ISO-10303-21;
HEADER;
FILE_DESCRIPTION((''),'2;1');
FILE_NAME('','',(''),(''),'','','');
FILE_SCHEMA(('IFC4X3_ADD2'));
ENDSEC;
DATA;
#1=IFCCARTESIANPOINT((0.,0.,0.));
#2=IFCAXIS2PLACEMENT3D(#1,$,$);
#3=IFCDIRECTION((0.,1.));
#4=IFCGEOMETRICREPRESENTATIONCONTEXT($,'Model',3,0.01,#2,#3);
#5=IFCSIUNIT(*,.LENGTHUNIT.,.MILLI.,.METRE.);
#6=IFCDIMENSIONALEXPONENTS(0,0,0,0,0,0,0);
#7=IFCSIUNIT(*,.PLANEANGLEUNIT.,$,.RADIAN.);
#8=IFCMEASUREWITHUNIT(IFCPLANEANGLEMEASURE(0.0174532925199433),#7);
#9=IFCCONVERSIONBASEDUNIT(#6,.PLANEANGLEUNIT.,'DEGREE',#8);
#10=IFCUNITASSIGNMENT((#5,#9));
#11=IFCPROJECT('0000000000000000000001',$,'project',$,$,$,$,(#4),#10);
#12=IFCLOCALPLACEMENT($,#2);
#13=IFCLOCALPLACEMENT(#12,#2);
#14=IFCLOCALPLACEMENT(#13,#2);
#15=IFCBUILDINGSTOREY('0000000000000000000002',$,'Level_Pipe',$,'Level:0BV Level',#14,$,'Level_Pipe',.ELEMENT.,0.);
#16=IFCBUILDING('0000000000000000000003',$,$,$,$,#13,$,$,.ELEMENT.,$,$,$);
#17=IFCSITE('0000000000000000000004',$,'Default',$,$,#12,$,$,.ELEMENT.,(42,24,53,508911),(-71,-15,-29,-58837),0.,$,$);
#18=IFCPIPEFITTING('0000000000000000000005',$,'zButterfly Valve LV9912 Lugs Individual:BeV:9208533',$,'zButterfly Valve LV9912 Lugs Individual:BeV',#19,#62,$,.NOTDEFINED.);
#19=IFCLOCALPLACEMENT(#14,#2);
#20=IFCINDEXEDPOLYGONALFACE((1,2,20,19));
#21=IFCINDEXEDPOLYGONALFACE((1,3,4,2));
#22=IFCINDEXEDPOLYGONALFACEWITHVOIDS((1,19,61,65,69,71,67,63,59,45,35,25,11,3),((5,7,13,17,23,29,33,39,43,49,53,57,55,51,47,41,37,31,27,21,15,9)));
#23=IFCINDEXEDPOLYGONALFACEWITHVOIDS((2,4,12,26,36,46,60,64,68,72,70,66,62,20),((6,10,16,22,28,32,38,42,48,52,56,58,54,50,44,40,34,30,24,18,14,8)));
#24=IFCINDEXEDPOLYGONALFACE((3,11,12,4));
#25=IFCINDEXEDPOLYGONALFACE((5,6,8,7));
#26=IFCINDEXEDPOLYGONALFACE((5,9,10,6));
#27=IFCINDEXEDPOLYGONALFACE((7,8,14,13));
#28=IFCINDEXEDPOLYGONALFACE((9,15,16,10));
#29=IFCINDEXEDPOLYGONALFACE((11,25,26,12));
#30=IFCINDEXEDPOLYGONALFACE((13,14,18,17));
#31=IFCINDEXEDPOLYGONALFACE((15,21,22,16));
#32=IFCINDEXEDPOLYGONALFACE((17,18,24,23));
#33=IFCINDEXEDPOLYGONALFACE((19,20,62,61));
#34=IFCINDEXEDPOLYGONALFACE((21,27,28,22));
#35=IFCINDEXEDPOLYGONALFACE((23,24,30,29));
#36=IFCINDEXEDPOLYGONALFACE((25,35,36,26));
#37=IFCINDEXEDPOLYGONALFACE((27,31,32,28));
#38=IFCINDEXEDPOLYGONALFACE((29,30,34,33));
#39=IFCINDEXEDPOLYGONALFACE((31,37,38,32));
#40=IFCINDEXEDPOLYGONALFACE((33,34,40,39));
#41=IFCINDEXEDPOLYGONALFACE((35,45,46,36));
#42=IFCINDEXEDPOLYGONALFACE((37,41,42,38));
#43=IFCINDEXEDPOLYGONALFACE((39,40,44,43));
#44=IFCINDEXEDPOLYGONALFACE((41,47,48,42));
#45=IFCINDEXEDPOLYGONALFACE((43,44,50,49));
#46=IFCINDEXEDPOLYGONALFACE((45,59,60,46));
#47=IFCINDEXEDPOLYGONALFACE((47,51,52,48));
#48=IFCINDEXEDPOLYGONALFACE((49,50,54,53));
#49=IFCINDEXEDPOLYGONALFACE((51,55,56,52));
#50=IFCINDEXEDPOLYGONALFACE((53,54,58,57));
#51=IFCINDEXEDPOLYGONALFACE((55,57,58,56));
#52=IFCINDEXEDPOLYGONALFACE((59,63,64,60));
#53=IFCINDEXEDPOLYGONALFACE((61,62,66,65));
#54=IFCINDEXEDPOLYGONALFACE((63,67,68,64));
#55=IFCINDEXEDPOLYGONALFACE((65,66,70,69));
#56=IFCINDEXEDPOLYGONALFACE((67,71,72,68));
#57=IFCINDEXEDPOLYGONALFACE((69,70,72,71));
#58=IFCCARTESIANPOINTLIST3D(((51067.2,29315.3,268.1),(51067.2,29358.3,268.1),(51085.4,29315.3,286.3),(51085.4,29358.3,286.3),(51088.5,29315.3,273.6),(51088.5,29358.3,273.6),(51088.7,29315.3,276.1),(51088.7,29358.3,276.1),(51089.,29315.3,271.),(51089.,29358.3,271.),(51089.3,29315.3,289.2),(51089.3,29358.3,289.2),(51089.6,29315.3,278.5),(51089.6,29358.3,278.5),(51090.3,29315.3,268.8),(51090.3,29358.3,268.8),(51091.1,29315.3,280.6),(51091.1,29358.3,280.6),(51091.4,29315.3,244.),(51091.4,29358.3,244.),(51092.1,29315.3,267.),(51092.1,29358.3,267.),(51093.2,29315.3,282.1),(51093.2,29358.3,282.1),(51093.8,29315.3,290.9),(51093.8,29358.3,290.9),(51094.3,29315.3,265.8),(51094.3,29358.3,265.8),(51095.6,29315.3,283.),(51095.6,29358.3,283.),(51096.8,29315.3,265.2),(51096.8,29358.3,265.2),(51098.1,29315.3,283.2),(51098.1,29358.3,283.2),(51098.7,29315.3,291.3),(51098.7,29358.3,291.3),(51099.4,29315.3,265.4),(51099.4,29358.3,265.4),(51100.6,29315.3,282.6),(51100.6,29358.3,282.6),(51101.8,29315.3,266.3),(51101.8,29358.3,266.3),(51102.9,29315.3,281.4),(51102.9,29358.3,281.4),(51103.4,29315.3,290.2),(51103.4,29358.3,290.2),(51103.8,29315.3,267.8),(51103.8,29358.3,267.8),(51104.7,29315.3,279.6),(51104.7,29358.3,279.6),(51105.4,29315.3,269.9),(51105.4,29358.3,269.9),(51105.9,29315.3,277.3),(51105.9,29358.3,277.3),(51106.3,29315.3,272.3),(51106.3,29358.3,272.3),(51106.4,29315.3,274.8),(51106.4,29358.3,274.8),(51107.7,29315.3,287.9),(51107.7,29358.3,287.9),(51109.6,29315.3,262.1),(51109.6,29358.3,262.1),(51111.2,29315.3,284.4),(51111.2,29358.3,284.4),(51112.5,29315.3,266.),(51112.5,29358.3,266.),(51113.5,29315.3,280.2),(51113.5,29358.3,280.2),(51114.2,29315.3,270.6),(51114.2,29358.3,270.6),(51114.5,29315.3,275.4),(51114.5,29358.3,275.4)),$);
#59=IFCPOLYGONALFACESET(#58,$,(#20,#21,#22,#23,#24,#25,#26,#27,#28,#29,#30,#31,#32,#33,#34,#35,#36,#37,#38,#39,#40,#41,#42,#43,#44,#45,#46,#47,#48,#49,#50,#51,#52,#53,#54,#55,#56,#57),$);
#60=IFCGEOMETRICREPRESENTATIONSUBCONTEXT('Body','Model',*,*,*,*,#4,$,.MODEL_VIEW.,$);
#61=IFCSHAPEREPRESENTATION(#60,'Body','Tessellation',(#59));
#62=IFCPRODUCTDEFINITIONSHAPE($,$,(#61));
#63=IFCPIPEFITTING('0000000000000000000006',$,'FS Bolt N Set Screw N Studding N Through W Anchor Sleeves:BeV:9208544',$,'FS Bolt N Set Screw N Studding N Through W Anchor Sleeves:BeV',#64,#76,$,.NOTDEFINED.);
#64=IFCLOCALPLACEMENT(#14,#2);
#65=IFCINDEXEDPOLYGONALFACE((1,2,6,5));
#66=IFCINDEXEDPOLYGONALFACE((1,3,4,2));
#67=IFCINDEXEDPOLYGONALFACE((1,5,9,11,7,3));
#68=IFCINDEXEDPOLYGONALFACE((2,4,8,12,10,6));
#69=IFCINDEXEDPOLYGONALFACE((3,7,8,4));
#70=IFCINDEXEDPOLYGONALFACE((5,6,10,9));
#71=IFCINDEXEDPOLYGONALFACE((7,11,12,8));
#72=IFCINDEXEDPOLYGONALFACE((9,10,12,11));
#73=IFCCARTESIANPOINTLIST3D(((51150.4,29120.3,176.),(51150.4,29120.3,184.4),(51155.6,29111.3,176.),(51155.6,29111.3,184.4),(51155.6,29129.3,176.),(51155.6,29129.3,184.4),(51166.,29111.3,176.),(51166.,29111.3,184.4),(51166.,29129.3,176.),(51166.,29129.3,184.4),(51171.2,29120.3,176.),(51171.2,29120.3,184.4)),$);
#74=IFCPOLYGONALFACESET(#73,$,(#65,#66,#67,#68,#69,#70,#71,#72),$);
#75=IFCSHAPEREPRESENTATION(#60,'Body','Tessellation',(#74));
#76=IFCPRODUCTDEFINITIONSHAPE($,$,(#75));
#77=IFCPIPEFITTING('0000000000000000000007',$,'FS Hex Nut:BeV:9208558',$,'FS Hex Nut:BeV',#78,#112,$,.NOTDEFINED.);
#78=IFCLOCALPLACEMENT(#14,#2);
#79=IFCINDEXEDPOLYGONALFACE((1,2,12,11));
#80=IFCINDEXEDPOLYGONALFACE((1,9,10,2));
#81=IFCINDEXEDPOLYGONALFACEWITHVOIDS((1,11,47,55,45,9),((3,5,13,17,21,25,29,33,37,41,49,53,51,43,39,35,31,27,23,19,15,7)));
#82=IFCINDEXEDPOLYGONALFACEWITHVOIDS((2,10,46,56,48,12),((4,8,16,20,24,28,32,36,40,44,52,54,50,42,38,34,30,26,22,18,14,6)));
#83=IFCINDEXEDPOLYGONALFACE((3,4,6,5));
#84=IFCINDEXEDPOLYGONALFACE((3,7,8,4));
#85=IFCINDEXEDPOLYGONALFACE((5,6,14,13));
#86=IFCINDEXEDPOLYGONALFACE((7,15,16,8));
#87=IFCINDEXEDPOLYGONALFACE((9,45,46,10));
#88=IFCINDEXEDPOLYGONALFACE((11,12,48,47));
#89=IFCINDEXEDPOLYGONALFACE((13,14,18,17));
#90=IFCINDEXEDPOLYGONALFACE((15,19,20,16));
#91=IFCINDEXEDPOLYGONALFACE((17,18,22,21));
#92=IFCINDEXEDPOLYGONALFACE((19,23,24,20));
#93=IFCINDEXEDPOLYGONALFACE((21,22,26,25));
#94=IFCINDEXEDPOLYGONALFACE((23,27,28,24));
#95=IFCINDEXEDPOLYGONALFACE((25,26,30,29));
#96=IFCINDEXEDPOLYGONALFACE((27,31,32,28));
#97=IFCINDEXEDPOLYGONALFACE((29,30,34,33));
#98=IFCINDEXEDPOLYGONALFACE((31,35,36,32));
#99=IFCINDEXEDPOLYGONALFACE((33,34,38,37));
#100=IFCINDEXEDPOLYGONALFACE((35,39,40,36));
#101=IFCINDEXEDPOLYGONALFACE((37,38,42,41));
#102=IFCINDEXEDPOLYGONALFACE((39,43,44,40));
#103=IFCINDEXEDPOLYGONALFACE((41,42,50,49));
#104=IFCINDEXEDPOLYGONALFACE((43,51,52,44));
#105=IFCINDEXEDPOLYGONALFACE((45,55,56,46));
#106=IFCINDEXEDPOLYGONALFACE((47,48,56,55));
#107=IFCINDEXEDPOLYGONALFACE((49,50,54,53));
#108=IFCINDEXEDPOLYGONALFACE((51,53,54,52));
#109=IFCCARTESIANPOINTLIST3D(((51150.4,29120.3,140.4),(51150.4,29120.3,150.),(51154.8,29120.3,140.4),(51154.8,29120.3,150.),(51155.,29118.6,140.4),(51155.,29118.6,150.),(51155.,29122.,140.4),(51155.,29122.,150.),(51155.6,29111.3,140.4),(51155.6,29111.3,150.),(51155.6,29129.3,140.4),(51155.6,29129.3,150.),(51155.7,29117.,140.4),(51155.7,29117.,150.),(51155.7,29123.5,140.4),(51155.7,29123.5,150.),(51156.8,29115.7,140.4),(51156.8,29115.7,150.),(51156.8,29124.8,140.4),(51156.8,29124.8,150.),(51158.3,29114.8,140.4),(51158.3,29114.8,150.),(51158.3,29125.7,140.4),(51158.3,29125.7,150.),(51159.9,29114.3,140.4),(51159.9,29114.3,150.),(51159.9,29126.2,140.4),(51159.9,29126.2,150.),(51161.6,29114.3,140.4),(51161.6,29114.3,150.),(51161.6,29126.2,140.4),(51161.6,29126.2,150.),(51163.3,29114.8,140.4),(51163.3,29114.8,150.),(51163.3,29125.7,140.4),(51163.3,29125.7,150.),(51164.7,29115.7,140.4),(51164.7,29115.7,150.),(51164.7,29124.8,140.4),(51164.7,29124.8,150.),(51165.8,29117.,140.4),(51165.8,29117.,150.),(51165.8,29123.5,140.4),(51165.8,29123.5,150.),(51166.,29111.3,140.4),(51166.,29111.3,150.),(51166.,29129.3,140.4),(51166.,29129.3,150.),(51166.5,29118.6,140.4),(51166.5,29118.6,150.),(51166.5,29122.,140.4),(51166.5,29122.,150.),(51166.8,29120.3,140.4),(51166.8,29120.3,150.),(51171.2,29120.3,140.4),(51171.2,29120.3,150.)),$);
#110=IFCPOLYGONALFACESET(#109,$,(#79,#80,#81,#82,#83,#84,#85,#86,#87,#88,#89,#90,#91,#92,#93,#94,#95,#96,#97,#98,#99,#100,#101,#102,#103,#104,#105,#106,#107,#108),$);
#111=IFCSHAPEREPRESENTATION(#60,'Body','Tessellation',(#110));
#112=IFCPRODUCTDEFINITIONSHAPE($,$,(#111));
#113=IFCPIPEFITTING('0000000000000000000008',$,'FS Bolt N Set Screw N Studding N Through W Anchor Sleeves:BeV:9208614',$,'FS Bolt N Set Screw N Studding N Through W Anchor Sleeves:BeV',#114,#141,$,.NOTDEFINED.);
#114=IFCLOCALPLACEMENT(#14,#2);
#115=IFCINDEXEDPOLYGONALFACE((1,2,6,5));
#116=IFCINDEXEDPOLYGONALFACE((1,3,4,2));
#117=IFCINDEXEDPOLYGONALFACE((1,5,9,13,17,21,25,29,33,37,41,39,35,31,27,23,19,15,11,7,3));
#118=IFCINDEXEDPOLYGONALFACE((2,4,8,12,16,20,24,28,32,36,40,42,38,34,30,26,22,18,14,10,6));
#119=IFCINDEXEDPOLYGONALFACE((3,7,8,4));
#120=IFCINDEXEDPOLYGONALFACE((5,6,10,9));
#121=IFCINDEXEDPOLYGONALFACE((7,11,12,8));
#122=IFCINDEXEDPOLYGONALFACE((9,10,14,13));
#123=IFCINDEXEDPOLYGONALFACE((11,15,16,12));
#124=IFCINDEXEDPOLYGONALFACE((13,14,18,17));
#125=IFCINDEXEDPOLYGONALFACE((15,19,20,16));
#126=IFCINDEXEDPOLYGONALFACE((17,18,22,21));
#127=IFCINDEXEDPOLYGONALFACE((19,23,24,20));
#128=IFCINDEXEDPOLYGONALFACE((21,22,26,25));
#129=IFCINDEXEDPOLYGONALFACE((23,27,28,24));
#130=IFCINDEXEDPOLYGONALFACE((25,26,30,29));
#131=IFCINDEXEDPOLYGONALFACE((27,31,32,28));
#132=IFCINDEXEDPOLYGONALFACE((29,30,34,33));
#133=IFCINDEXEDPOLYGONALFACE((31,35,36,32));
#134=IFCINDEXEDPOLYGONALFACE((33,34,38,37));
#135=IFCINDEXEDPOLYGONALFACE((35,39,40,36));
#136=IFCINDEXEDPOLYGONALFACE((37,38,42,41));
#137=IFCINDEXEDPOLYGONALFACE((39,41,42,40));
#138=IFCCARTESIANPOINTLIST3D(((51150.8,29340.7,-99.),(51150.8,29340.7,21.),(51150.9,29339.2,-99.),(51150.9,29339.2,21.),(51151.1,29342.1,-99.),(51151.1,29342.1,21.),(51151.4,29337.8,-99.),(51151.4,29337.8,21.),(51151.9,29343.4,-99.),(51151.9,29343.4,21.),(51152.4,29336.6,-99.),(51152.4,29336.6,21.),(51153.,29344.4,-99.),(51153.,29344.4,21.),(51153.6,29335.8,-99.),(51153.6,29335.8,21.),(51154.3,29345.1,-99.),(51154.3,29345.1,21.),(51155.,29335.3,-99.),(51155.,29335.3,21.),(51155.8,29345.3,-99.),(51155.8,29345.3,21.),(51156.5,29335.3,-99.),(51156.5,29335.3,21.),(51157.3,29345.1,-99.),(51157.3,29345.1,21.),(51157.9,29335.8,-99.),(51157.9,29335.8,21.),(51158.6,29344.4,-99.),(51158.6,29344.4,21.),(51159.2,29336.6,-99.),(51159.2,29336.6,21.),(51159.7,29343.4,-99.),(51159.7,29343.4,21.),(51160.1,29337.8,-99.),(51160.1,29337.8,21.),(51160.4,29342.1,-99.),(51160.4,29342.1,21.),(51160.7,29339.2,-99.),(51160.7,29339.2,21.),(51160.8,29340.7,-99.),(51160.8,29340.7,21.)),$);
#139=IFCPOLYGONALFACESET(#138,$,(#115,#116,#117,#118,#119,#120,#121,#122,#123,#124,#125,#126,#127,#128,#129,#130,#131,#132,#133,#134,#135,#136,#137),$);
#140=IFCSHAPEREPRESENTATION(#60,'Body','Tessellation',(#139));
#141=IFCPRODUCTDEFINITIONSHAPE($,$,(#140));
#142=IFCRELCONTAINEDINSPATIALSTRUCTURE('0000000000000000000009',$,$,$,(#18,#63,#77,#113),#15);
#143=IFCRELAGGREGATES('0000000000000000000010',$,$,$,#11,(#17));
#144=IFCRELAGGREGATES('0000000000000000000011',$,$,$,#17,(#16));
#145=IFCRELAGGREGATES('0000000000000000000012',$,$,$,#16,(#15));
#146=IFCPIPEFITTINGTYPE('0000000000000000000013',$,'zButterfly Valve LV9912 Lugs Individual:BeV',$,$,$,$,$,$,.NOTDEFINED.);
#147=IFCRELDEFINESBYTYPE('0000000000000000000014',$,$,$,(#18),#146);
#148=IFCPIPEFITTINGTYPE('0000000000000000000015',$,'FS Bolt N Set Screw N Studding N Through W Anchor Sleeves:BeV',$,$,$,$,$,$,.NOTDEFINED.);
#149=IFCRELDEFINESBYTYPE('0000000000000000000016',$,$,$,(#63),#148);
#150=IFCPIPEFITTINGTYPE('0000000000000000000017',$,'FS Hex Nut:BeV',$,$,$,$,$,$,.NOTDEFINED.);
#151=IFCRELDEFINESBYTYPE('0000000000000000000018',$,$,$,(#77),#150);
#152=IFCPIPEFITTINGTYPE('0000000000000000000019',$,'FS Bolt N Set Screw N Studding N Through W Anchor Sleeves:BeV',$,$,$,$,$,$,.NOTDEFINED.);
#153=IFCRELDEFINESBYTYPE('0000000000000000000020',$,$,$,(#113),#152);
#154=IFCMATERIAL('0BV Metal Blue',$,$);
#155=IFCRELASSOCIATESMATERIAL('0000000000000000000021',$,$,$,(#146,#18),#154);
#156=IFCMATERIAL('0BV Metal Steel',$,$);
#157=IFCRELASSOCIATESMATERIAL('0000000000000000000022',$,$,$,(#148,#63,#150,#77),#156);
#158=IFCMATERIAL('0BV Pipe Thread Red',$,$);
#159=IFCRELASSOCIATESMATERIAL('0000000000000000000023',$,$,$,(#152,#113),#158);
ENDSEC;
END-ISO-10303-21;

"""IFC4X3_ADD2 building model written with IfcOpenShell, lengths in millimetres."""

from ifc_helpers import new_model, entity, si_unit, converted_unit, direction, frame, frame_2d, origin, place, context, subcontext, project, spatial, polyline, circle_curve, parameter, trimmed, segment, composite_curve, circle, outline, extrude, source, transform, mapped, material, type_object, type_shapes, element, save


model = new_model("IFC4X3_ADD2")

# Units and contexts
model_context = context("Model", 3, precision=0.01, world=origin(), true_north=direction((0.0, 1.0)))
body_context = subcontext(model_context, "Body", "Model", "MODEL_VIEW")
ifc_project = project(units=[si_unit("LENGTHUNIT", "METRE", prefix="MILLI"), converted_unit("PLANEANGLEUNIT", "DEGREE", entity("IfcPlaneAngleMeasure", 0.0174532925199433), si_unit("PLANEANGLEUNIT", "RADIAN"), dimensions=[0, 0, 0, 0, 0, 0, 0])], contexts=[model_context])

# Site, building, storey
site_placement = place(None, origin())
site = spatial("IfcSite", under=ifc_project, at=site_placement, Name="Default", CompositionType="ELEMENT", RefLatitude=(42, 24, 53, 508911), RefLongitude=(-71, -15, -29, -58837), RefElevation=0.0)
building_placement = place(site_placement, origin())
building = spatial("IfcBuilding", under=site, at=building_placement, CompositionType="ELEMENT")
storey_placement = place(building_placement, origin())
storey = spatial("IfcBuildingStorey", under=building, at=storey_placement, Name="Level_Pipe", ObjectType="Level:0BV Level", LongName="Level_Pipe", CompositionType="ELEMENT", Elevation=0.0)

# Pipe fittings
ifc_material_1 = material(Name="0BV Metal Blue")
pipe_fitting_type_1 = type_object("IfcPipeFittingType", Name="zButterfly Valve LV9912 Lugs Individual:BeV", PredefinedType="NOTDEFINED", material=ifc_material_1)
shared_shape_1 = source(origin(), body_context, "Body", "SweptSolid", [
    extrude(outline(composite_curve([segment(polyline([(-17.1, -12.8), (17.1, -12.8)]), True, "CONTINUOUS"), segment(polyline([(17.1, -12.8), (17.1, 12.8)]), True, "CONTINUOUS"), segment(trimmed(circle_curve(frame_2d((0.0, 12.8), x_axis=(1.0, 0.0)), 17.1), [parameter(360.0)], [parameter(180.0)], True, "PARAMETER"), True, "CONTINUOUS"), segment(polyline([(-17.1, 12.8), (-17.1, -12.8)]), True, "CONTINUOUS")], self_intersect=False), holes=[composite_curve([segment(trimmed(circle_curve(frame_2d((0.0, 12.8), x_axis=(1.0, 0.0)), 9.0), [parameter(0.0)], [parameter(180.0)], True, "PARAMETER"), False, "CONTINUOUS"), segment(trimmed(circle_curve(frame_2d((0.0, 12.8), x_axis=(1.0, 0.0)), 9.0), [parameter(180.0)], [parameter(0.0)], True, "PARAMETER"), False, "CONTINUOUS")], self_intersect=False)]), frame((0.0, -12.8, -21.5)), (0.0, 0.0, 1.0), 43.0),
])
type_shapes(pipe_fitting_type_1, [shared_shape_1])
for number, where, z_axis, x_axis, name in (
    (1, (51097.5, 29336.8, 274.2), (0.0, 1.0, 0.0), (-0.707107, 0.0, 0.707107), "zButterfly Valve LV9912 Lugs Individual:BeV:9208533"),
):
    element("IfcPipeFitting", number, at=place(storey_placement, frame(where, z_axis=z_axis, x_axis=x_axis)), inside=storey, type_object=pipe_fitting_type_1, material=ifc_material_1, Name=name, ObjectType="zButterfly Valve LV9912 Lugs Individual:BeV", PredefinedType="NOTDEFINED", context=body_context, shape_type="MappedRepresentation", body=[
        mapped(shared_shape_1, transform((0.0, 0.0, 0.0), scale=1.0)),
    ])
ifc_material_2 = material(Name="0BV Metal Steel")
pipe_fitting_type_2 = type_object("IfcPipeFittingType", Name="FS Bolt N Set Screw N Studding N Through W Anchor Sleeves:BeV", PredefinedType="NOTDEFINED", material=ifc_material_2)
shared_shape_2 = source(origin(), body_context, "Body", "SweptSolid", [
    extrude(outline(polyline([(-5.2, -9.0), (5.2, -9.0), (10.4, 0.0), (5.2, 9.0), (-5.2, 9.0), (-10.4, 0.0), (-5.2, -9.0)])), frame((-8.4, 0.0, 0.0), z_axis=(1.0, 0.0, 0.0), x_axis=(0.0, -0.5, -0.866025)), (0.0, 0.0, 1.0), 8.4),
])
type_shapes(pipe_fitting_type_2, [shared_shape_2])
pipe_fitting_1_placement = place(storey_placement, frame((51160.8, 29120.3, 176.0), z_axis=(0.0, 1.0, 0.0), x_axis=(0.0, 0.0, -1.0)))
element("IfcPipeFitting", 2, at=pipe_fitting_1_placement, inside=storey, type_object=pipe_fitting_type_2, material=ifc_material_2, Name="FS Bolt N Set Screw N Studding N Through W Anchor Sleeves:BeV:9208544", ObjectType="FS Bolt N Set Screw N Studding N Through W Anchor Sleeves:BeV", PredefinedType="NOTDEFINED", context=body_context, shape_type="MappedRepresentation", body=[
    mapped(shared_shape_2, transform((0.0, 0.0, 0.0), scale=1.0)),
])
pipe_fitting_type_3 = type_object("IfcPipeFittingType", Name="FS Hex Nut:BeV", PredefinedType="NOTDEFINED", material=ifc_material_2)
shared_shape_3 = source(origin(), body_context, "Body", "SweptSolid", [
    extrude(outline(polyline([(-5.2, -9.0), (5.2, -9.0), (10.4, 0.0), (5.2, 9.0), (-5.2, 9.0), (-10.4, 0.0), (-5.2, -9.0)]), holes=[composite_curve([segment(trimmed(circle_curve(frame_2d((0.0, 0.0), x_axis=(-0.5, 0.866025)), 6.0), [parameter(0.0)], [parameter(180.0)], True, "PARAMETER"), False, "CONTINUOUS"), segment(trimmed(circle_curve(frame_2d((0.0, 0.0), x_axis=(-0.5, 0.866025)), 6.0), [parameter(180.0)], [parameter(360.0)], True, "PARAMETER"), False, "CONTINUOUS")], self_intersect=False)]), frame((0.0, 10.4, 9.0), z_axis=(1.0, 0.0, 0.0), x_axis=(0.0, -0.5, -0.866025)), (0.0, 0.0, 1.0), 9.6),
])
type_shapes(pipe_fitting_type_3, [shared_shape_3])
pipe_fitting_2_placement = place(storey_placement, frame((51171.2, 29111.3, 150.0), z_axis=(0.0, 1.0, 0.0), x_axis=(0.0, 0.0, -1.0)))
element("IfcPipeFitting", 3, at=pipe_fitting_2_placement, inside=storey, type_object=pipe_fitting_type_3, material=ifc_material_2, Name="FS Hex Nut:BeV:9208558", ObjectType="FS Hex Nut:BeV", PredefinedType="NOTDEFINED", context=body_context, shape_type="MappedRepresentation", body=[
    mapped(shared_shape_3, transform((0.0, 0.0, 0.0), scale=1.0)),
])
ifc_material_3 = material(Name="0BV Pipe Thread Red")
pipe_fitting_type_4 = type_object("IfcPipeFittingType", Name="FS Bolt N Set Screw N Studding N Through W Anchor Sleeves:BeV", PredefinedType="NOTDEFINED", material=ifc_material_3)
shared_shape_4 = source(origin(), body_context, "Body", "SweptSolid", [
    extrude(circle(Radius=5.0, at=frame_2d((0.0, 0.0), x_axis=(1.0, 0.0))), frame((-16.0, 0.0, 0.0), z_axis=(1.0, 0.0, 0.0), x_axis=(0.0, 1.0, 0.0)), (0.0, 0.0, 1.0), 120.0),
])
type_shapes(pipe_fitting_type_4, [shared_shape_4])
pipe_fitting_3_placement = place(storey_placement, frame((51155.8, 29340.3, 5.0), z_axis=(1.0, 0.0, 0.0), x_axis=(0.0, 0.0, -1.0)))
element("IfcPipeFitting", 4, at=pipe_fitting_3_placement, inside=storey, type_object=pipe_fitting_type_4, material=ifc_material_3, Name="FS Bolt N Set Screw N Studding N Through W Anchor Sleeves:BeV:9208614", ObjectType="FS Bolt N Set Screw N Studding N Through W Anchor Sleeves:BeV", PredefinedType="NOTDEFINED", context=body_context, shape_type="MappedRepresentation", body=[
    mapped(shared_shape_4, transform((0.0, 0.0, 0.0), scale=1.0)),
])

save(model, "model.ifc")
